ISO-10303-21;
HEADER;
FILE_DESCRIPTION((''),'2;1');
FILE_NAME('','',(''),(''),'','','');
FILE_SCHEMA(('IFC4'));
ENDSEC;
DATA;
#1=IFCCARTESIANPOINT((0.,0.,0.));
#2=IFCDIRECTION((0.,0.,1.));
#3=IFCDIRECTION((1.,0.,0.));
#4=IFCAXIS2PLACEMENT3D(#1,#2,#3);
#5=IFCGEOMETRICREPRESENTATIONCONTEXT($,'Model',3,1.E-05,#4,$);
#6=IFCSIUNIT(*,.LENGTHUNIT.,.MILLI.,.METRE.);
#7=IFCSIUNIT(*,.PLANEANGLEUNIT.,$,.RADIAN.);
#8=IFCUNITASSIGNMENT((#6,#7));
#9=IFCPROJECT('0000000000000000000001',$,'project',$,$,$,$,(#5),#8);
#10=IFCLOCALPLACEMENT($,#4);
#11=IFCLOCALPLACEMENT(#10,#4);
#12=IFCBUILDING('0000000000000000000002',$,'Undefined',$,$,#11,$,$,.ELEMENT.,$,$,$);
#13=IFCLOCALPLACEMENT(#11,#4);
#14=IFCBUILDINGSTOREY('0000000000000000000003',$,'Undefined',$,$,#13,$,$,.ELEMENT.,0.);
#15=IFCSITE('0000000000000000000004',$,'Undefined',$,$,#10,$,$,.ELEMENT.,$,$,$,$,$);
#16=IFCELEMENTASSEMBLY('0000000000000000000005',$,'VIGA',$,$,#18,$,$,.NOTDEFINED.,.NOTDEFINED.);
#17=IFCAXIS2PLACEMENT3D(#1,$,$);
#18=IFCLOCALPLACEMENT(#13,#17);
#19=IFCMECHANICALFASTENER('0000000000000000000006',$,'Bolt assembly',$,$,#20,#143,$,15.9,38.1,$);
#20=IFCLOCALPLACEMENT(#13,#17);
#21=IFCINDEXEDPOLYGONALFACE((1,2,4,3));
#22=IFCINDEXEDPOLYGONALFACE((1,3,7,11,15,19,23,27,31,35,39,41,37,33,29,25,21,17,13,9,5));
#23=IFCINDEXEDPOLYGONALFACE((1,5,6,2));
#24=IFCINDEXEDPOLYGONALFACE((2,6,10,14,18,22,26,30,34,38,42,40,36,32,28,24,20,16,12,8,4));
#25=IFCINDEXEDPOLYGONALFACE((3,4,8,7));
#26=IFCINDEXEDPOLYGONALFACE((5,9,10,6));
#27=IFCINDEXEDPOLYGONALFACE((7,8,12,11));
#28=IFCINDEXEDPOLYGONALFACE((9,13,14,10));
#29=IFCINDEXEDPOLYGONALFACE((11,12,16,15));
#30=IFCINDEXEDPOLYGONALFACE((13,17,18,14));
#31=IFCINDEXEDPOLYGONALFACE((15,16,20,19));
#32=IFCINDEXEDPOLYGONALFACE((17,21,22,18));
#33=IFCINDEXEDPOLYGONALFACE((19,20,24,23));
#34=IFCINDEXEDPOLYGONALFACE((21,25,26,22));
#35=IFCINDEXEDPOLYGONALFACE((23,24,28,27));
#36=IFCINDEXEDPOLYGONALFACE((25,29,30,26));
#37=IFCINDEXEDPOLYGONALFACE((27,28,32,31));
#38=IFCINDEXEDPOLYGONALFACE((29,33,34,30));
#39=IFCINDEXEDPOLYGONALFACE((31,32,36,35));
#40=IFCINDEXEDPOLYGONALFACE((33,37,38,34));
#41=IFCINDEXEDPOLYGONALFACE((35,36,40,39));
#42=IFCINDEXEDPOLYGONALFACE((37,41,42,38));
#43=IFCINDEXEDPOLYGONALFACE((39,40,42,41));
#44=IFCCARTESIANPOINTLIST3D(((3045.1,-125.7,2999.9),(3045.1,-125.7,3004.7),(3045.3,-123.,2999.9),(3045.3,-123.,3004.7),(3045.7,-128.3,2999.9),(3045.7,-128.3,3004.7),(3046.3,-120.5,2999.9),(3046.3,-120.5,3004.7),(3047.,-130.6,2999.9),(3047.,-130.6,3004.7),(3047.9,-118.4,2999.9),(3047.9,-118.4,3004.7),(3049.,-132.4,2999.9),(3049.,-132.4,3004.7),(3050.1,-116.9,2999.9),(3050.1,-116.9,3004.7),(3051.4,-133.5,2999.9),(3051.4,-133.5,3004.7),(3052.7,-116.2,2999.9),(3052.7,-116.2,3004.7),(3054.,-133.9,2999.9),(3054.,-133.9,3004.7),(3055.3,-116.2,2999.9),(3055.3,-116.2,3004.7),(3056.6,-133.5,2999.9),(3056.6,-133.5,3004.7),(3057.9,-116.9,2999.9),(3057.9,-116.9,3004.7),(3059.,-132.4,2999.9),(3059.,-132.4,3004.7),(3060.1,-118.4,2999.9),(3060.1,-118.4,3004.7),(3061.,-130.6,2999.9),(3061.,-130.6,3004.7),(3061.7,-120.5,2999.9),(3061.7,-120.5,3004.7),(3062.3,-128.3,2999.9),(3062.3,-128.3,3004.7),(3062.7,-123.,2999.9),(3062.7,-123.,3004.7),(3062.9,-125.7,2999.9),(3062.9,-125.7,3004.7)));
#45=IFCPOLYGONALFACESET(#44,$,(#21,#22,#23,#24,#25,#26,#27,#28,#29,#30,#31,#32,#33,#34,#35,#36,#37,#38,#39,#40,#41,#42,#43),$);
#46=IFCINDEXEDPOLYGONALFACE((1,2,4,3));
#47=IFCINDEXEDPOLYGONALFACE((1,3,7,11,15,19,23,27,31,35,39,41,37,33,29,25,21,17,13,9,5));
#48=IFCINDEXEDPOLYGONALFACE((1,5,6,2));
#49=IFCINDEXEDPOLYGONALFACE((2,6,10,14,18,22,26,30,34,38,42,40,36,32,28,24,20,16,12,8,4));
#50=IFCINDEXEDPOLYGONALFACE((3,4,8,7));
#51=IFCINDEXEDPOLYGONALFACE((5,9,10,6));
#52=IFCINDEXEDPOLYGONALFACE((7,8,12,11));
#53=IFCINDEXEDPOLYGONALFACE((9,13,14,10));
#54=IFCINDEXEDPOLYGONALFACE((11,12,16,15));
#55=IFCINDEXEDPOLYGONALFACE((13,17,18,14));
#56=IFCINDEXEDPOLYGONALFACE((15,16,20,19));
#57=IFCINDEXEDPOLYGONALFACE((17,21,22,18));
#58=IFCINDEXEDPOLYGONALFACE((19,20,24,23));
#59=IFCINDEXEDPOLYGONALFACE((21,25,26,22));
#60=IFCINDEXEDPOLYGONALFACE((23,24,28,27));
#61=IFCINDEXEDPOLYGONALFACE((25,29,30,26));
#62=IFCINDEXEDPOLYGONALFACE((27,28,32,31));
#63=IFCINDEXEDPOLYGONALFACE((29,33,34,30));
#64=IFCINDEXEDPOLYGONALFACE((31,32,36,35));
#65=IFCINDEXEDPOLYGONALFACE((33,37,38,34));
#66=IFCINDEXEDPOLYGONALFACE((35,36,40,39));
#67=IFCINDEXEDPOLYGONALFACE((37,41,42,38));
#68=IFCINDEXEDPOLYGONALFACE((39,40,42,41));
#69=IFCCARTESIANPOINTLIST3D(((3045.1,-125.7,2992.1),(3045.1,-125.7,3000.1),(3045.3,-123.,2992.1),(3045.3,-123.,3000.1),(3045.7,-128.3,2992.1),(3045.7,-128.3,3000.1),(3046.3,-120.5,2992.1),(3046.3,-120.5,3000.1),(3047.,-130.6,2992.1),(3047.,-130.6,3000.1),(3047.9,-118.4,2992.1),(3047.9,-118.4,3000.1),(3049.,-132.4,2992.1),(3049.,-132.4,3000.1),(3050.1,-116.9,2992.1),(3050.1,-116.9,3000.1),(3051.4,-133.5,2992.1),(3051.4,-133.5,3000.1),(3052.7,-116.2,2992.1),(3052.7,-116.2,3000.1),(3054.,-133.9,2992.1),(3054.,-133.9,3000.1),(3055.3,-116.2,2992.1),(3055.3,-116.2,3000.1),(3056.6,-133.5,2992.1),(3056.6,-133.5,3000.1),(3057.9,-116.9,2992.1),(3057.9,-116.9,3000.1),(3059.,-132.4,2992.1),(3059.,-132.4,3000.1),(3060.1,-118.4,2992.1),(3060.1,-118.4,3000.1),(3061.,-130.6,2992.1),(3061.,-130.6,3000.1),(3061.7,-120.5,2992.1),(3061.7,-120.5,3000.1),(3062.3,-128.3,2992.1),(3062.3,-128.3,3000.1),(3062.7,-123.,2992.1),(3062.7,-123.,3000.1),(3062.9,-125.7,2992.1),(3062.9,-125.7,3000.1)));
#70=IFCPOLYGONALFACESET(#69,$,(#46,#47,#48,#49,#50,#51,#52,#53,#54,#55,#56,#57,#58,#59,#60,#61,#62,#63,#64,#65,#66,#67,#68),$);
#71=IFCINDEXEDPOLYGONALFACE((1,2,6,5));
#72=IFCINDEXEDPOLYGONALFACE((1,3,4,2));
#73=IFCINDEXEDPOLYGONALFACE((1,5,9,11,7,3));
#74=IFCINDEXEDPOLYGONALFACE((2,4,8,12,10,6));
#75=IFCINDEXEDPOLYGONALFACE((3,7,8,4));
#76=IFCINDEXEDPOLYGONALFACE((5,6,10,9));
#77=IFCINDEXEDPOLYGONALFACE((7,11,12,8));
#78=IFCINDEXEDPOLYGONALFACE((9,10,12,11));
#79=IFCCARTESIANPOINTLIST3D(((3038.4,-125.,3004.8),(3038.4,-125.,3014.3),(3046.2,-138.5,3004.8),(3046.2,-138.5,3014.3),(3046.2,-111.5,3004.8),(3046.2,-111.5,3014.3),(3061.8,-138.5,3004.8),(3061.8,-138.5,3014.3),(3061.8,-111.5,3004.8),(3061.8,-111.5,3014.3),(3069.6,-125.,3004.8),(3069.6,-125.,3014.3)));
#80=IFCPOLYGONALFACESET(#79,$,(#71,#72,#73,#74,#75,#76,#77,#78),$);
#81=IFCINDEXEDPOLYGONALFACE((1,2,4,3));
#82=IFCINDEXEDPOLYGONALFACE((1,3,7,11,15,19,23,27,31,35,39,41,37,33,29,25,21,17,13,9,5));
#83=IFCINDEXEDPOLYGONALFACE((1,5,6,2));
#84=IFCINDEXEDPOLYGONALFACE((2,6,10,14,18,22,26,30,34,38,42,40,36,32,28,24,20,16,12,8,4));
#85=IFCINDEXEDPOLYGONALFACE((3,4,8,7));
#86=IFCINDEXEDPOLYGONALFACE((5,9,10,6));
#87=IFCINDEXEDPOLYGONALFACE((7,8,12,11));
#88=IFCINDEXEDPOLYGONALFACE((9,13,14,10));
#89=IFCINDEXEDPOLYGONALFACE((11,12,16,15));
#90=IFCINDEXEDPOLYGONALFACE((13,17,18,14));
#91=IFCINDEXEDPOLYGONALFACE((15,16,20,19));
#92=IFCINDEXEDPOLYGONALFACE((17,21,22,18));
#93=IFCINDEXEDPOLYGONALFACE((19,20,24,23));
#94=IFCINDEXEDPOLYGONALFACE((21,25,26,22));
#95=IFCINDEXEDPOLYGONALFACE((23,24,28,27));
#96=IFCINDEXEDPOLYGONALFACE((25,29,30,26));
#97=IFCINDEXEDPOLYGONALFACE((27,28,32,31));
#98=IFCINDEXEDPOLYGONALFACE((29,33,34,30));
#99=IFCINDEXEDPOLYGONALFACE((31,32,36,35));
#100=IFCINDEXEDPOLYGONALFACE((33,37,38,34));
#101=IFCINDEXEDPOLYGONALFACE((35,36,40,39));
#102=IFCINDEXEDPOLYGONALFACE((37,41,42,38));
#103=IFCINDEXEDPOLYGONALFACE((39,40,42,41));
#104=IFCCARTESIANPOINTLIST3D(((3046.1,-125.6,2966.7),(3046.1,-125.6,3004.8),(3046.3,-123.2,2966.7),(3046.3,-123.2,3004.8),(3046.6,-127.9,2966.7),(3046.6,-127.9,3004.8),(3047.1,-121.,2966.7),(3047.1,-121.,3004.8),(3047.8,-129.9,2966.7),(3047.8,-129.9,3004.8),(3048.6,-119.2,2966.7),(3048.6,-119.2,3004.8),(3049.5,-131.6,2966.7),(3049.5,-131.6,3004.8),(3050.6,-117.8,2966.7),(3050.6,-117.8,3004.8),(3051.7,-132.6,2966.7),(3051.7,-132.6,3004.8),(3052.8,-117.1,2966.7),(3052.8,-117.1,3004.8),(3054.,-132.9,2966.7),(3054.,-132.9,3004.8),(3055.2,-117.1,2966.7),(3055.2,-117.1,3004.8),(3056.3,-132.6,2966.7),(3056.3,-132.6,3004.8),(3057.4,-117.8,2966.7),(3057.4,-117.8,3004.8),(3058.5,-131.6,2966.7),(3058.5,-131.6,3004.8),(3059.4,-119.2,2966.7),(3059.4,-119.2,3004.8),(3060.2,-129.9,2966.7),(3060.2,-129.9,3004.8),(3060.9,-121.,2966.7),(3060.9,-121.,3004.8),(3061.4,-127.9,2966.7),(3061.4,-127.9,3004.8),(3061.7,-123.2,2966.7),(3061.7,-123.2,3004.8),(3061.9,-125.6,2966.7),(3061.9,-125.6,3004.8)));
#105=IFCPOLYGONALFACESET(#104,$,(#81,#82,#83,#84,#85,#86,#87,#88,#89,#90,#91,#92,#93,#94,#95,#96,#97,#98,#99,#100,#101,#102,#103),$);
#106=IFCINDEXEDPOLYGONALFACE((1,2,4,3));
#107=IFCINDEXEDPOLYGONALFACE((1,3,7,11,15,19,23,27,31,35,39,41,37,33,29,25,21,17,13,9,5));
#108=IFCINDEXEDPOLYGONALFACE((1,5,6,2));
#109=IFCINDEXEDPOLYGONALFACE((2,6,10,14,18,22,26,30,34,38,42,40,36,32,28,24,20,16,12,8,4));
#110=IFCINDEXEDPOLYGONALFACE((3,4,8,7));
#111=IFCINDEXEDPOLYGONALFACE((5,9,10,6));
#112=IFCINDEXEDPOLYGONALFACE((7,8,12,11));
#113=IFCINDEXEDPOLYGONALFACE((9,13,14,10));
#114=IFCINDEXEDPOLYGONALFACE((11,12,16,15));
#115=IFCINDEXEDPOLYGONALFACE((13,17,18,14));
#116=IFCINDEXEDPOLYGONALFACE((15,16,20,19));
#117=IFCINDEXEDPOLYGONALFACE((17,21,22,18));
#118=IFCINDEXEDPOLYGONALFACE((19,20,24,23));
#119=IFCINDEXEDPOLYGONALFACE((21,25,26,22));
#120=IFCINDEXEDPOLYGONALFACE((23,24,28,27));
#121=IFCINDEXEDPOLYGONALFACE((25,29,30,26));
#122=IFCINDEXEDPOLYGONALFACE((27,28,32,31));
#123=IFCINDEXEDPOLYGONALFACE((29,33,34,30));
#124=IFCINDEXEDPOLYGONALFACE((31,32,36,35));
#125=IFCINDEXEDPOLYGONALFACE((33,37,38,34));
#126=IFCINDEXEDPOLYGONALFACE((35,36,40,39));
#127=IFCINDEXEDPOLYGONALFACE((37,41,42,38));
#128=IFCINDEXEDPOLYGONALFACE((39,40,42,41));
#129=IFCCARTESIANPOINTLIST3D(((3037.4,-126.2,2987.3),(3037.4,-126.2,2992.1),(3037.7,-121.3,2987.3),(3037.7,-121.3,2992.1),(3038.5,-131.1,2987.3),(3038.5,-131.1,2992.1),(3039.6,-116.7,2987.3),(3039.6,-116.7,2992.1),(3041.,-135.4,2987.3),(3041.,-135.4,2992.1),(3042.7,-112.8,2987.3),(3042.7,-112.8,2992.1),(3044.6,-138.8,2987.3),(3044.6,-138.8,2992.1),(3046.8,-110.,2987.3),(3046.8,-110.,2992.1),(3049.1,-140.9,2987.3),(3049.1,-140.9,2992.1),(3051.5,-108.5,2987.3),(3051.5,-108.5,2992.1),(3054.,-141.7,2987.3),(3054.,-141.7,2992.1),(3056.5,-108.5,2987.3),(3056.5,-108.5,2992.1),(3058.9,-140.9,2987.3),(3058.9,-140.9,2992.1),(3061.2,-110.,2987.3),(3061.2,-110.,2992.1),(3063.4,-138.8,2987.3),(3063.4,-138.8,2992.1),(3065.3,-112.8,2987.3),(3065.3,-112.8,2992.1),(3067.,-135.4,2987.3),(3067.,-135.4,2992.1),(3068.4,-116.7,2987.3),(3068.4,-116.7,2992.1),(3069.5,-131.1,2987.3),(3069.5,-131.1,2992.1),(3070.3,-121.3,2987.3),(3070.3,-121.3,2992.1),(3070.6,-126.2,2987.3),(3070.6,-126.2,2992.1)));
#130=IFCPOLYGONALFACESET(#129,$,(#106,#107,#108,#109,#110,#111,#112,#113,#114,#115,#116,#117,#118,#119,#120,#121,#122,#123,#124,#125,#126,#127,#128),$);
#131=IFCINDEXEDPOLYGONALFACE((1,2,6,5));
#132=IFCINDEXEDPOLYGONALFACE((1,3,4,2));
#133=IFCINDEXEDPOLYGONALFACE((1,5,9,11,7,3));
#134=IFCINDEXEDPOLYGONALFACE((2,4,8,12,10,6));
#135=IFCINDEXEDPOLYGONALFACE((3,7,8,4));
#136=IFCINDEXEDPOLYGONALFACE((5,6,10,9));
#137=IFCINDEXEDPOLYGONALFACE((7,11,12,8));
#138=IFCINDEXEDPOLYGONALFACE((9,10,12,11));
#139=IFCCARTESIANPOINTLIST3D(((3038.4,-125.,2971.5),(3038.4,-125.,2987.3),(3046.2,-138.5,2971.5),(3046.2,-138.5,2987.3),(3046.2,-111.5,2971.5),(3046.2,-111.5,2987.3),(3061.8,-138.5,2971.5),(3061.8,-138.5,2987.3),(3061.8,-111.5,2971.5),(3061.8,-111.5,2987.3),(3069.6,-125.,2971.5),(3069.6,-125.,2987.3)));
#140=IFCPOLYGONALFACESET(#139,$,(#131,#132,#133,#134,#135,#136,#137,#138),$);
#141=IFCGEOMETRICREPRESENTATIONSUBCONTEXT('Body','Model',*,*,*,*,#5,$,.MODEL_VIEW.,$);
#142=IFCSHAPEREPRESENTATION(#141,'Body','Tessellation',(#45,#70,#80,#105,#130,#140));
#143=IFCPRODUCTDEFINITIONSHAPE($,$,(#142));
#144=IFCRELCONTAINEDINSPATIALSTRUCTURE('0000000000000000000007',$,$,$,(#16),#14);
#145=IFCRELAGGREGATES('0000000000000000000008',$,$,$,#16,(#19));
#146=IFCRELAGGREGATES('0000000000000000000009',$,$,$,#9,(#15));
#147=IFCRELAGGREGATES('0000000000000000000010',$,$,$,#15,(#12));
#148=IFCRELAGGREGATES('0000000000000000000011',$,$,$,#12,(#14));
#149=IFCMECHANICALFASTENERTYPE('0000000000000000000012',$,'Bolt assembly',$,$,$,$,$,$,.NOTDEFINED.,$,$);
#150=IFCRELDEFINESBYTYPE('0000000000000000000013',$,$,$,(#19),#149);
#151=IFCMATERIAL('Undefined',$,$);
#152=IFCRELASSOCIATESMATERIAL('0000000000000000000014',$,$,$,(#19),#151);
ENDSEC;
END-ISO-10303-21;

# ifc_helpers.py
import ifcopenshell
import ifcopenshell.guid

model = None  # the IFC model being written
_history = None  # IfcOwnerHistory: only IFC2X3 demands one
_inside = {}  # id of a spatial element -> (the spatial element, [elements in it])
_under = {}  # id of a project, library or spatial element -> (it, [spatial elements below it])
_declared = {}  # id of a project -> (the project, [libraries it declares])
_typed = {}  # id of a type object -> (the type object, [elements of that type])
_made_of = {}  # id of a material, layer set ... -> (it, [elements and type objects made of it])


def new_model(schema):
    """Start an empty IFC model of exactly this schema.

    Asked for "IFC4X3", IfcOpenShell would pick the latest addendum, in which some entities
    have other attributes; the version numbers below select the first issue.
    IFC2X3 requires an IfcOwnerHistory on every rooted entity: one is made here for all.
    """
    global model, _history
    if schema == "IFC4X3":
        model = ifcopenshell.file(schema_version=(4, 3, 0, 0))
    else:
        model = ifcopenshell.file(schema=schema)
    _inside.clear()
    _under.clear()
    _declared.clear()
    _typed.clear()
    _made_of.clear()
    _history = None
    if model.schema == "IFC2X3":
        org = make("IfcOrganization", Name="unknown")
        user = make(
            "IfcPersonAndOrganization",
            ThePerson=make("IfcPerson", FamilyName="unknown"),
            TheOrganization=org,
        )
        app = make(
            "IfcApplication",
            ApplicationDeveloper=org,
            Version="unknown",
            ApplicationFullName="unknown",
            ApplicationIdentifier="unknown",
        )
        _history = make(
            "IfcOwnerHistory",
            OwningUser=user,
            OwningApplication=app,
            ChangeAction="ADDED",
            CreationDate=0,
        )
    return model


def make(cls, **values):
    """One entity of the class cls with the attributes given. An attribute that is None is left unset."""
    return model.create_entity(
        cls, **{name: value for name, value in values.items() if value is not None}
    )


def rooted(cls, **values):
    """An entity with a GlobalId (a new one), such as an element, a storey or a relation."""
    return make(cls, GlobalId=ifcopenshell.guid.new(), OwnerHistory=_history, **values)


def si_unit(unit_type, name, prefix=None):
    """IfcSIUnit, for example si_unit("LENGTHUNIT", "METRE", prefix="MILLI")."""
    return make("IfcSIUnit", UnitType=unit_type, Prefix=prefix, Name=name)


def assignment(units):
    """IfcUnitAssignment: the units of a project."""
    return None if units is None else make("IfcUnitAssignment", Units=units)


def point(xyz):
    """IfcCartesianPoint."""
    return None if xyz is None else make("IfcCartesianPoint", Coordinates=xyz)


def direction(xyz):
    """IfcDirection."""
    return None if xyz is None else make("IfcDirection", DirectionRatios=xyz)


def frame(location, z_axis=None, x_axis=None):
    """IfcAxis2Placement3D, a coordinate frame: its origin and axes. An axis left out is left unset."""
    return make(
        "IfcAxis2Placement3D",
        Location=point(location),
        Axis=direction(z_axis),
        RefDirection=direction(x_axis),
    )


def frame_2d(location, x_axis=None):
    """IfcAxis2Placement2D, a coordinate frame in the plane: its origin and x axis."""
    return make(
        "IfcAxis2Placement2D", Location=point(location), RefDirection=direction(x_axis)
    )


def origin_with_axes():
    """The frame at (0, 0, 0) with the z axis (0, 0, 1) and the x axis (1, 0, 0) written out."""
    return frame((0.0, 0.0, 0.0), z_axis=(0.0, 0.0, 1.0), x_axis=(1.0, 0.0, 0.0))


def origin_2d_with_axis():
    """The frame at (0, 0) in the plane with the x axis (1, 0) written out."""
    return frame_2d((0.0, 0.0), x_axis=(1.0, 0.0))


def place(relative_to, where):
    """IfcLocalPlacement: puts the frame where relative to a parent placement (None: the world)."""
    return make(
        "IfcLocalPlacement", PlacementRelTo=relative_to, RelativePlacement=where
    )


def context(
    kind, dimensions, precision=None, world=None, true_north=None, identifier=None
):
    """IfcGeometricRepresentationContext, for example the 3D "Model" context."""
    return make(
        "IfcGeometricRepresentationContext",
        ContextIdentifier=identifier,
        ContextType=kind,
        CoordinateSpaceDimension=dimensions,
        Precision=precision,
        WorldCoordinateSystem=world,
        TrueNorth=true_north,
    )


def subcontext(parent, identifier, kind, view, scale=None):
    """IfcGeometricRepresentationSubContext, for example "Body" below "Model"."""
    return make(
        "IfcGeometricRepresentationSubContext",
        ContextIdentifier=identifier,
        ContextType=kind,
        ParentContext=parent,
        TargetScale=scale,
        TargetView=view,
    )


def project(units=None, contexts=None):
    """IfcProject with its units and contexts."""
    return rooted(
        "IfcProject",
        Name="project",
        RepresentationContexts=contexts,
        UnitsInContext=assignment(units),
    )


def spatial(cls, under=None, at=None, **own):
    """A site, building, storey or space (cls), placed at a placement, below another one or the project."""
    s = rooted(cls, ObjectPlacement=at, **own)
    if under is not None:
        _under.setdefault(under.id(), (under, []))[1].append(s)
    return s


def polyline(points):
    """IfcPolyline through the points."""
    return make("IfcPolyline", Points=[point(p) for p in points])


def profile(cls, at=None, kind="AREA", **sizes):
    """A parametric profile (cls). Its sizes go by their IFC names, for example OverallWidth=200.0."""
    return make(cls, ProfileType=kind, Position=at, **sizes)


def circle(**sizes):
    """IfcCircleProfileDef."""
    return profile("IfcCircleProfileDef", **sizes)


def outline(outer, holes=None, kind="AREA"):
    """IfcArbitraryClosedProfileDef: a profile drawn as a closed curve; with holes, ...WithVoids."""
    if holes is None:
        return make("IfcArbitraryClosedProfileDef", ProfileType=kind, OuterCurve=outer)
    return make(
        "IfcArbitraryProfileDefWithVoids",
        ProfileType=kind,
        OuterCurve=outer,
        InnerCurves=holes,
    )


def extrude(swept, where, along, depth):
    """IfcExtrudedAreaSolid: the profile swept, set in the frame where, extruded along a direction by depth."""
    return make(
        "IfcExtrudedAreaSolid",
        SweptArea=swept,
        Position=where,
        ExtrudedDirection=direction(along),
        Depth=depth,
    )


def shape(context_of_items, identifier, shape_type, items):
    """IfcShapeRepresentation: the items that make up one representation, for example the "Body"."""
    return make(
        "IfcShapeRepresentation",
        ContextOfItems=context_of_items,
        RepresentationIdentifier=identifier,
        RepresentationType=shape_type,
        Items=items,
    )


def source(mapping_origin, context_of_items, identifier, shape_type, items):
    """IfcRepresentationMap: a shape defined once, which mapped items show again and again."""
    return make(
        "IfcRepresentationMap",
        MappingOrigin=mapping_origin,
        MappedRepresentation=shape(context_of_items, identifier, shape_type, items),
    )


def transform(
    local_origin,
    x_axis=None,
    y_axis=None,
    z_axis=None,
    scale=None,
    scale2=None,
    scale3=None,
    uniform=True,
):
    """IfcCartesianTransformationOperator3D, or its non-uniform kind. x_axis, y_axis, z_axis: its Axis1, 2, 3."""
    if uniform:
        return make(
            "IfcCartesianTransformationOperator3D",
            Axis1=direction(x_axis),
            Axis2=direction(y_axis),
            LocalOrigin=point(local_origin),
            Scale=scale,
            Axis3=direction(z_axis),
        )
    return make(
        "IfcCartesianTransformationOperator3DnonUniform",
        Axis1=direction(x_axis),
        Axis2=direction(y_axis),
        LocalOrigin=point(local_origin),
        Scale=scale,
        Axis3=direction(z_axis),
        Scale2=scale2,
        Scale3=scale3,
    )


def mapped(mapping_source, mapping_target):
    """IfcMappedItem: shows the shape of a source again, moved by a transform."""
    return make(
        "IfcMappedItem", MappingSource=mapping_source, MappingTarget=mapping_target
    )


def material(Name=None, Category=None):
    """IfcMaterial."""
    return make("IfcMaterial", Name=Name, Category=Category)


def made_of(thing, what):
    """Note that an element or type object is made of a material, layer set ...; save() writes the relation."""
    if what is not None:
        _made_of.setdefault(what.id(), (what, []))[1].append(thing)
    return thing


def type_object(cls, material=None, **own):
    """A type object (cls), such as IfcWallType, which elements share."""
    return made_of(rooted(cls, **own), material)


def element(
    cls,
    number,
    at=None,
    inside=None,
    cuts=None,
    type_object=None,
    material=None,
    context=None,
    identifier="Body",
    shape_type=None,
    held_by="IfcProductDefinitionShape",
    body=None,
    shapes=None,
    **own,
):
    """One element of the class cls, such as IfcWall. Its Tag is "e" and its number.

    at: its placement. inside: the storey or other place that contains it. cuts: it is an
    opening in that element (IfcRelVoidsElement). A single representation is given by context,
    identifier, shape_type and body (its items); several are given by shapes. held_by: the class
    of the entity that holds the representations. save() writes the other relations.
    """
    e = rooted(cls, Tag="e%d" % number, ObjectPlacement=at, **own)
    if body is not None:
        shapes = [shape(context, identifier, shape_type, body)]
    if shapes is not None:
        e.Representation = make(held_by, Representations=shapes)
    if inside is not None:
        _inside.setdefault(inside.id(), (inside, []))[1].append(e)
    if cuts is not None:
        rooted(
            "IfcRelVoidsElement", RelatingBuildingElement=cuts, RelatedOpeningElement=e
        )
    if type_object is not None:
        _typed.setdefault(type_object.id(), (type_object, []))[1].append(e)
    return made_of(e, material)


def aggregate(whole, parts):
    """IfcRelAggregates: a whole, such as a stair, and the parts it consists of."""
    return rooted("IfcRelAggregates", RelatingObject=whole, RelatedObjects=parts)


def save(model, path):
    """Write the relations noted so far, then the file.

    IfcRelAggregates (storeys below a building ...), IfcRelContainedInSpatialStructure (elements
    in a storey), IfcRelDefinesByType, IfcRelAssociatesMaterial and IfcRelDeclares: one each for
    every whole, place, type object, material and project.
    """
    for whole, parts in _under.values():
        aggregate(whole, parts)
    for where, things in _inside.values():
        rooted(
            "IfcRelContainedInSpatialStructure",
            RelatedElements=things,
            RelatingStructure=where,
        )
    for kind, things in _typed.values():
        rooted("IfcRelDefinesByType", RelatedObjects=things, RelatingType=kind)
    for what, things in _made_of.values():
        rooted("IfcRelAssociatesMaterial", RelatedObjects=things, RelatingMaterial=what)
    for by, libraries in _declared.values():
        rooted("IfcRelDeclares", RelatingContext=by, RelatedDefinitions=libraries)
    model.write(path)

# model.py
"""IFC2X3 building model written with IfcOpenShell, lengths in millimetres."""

from ifc_helpers import new_model, si_unit, frame, origin_with_axes, origin_2d_with_axis, place, context, subcontext, project, spatial, polyline, circle, outline, extrude, source, transform, mapped, material, type_object, element, aggregate, save


model = new_model("IFC2X3")

# Units and contexts
model_context = context("Model", 3, precision=1e-05, world=origin_with_axes())
body_context = subcontext(model_context, "Body", "Model", "MODEL_VIEW")
ifc_project = project(units=[si_unit("LENGTHUNIT", "METRE", prefix="MILLI"), si_unit("PLANEANGLEUNIT", "RADIAN")], contexts=[model_context])

# Site, building, storey
site_placement = place(None, origin_with_axes())
site = spatial("IfcSite", under=ifc_project, at=site_placement, Name="Undefined", CompositionType="ELEMENT")
building_placement = place(site_placement, origin_with_axes())
building = spatial("IfcBuilding", under=site, at=building_placement, Name="Undefined", CompositionType="ELEMENT")
storey_placement = place(building_placement, origin_with_axes())
storey = spatial("IfcBuildingStorey", under=building, at=storey_placement, Name="Undefined", CompositionType="ELEMENT", Elevation=0.0)

# Element assembly
assembly_1_placement = place(storey_placement, origin_with_axes())
assembly_1 = element("IfcElementAssembly", 1, at=assembly_1_placement, inside=storey, Name="VIGA", AssemblyPlace="NOTDEFINED", PredefinedType="NOTDEFINED")

# Mechanical fastener
ifc_material_1 = material(Name="Undefined")
mechanical_fastener_type = type_object("IfcMechanicalFastenerType", Name="Bolt assembly")
shared_shape_1 = source(origin_with_axes(), body_context, "Body", "SweptSolid", [
    extrude(circle(Radius=8.9, at=origin_2d_with_axis()), frame((0.0, -4.7, 0.0), z_axis=(0.0, 1.0, 0.0), x_axis=(1.0, 0.0, 0.0)), (0.0, 0.0, 1.0), 4.8),
    extrude(circle(Radius=8.9, at=origin_2d_with_axis()), frame((0.0, -0.1, 0.0), z_axis=(0.0, 1.0, 0.0), x_axis=(1.0, 0.0, 0.0)), (0.0, 0.0, 1.0), 8.0),
    extrude(outline(polyline([(13.5, -7.8), (13.5, 7.8), (0.0, 15.6), (-13.5, 7.8), (-13.5, -7.8), (0.0, -15.6), (13.5, -7.8)])), frame((0.0, -14.3, 0.0), z_axis=(0.0, 1.0, 0.0), x_axis=(1.0, 0.0, 0.0)), (0.0, 0.0, 1.0), 9.5),
    extrude(circle(Radius=7.9, at=origin_2d_with_axis()), frame((0.0, -4.8, 0.0), z_axis=(0.0, 1.0, 0.0), x_axis=(1.0, 0.0, 0.0)), (0.0, 0.0, 1.0), 38.1),
    extrude(circle(Radius=16.7, at=origin_2d_with_axis()), frame((0.0, 7.9, 0.0), z_axis=(0.0, 1.0, 0.0), x_axis=(1.0, 0.0, 0.0)), (0.0, 0.0, 1.0), 4.8),
    extrude(outline(polyline([(13.5, -7.8), (13.5, 7.8), (0.0, 15.6), (-13.5, 7.8), (-13.5, -7.8), (0.0, -15.6), (13.5, -7.8)])), frame((0.0, 12.7, 0.0), z_axis=(0.0, 1.0, 0.0), x_axis=(1.0, 0.0, 0.0)), (0.0, 0.0, 1.0), 15.9),
])
mechanical_fastener_1_placement = place(assembly_1_placement, frame((3054.0, -125.0, 3000.0), z_axis=(1.0, -0.000001, 0.0), x_axis=(-0.000001, -1.0, 0.0)))
mechanical_fastener_1 = element("IfcMechanicalFastener", 2, at=mechanical_fastener_1_placement, type_object=mechanical_fastener_type, material=ifc_material_1, Name="Bolt assembly", NominalDiameter=15.9, NominalLength=38.1, context=body_context, shape_type="MappedRepresentation", body=[
    mapped(shared_shape_1, transform((0.0, 0.0, 0.0))),
])
aggregate(assembly_1, [mechanical_fastener_1])

save(model, "model.ifc")
